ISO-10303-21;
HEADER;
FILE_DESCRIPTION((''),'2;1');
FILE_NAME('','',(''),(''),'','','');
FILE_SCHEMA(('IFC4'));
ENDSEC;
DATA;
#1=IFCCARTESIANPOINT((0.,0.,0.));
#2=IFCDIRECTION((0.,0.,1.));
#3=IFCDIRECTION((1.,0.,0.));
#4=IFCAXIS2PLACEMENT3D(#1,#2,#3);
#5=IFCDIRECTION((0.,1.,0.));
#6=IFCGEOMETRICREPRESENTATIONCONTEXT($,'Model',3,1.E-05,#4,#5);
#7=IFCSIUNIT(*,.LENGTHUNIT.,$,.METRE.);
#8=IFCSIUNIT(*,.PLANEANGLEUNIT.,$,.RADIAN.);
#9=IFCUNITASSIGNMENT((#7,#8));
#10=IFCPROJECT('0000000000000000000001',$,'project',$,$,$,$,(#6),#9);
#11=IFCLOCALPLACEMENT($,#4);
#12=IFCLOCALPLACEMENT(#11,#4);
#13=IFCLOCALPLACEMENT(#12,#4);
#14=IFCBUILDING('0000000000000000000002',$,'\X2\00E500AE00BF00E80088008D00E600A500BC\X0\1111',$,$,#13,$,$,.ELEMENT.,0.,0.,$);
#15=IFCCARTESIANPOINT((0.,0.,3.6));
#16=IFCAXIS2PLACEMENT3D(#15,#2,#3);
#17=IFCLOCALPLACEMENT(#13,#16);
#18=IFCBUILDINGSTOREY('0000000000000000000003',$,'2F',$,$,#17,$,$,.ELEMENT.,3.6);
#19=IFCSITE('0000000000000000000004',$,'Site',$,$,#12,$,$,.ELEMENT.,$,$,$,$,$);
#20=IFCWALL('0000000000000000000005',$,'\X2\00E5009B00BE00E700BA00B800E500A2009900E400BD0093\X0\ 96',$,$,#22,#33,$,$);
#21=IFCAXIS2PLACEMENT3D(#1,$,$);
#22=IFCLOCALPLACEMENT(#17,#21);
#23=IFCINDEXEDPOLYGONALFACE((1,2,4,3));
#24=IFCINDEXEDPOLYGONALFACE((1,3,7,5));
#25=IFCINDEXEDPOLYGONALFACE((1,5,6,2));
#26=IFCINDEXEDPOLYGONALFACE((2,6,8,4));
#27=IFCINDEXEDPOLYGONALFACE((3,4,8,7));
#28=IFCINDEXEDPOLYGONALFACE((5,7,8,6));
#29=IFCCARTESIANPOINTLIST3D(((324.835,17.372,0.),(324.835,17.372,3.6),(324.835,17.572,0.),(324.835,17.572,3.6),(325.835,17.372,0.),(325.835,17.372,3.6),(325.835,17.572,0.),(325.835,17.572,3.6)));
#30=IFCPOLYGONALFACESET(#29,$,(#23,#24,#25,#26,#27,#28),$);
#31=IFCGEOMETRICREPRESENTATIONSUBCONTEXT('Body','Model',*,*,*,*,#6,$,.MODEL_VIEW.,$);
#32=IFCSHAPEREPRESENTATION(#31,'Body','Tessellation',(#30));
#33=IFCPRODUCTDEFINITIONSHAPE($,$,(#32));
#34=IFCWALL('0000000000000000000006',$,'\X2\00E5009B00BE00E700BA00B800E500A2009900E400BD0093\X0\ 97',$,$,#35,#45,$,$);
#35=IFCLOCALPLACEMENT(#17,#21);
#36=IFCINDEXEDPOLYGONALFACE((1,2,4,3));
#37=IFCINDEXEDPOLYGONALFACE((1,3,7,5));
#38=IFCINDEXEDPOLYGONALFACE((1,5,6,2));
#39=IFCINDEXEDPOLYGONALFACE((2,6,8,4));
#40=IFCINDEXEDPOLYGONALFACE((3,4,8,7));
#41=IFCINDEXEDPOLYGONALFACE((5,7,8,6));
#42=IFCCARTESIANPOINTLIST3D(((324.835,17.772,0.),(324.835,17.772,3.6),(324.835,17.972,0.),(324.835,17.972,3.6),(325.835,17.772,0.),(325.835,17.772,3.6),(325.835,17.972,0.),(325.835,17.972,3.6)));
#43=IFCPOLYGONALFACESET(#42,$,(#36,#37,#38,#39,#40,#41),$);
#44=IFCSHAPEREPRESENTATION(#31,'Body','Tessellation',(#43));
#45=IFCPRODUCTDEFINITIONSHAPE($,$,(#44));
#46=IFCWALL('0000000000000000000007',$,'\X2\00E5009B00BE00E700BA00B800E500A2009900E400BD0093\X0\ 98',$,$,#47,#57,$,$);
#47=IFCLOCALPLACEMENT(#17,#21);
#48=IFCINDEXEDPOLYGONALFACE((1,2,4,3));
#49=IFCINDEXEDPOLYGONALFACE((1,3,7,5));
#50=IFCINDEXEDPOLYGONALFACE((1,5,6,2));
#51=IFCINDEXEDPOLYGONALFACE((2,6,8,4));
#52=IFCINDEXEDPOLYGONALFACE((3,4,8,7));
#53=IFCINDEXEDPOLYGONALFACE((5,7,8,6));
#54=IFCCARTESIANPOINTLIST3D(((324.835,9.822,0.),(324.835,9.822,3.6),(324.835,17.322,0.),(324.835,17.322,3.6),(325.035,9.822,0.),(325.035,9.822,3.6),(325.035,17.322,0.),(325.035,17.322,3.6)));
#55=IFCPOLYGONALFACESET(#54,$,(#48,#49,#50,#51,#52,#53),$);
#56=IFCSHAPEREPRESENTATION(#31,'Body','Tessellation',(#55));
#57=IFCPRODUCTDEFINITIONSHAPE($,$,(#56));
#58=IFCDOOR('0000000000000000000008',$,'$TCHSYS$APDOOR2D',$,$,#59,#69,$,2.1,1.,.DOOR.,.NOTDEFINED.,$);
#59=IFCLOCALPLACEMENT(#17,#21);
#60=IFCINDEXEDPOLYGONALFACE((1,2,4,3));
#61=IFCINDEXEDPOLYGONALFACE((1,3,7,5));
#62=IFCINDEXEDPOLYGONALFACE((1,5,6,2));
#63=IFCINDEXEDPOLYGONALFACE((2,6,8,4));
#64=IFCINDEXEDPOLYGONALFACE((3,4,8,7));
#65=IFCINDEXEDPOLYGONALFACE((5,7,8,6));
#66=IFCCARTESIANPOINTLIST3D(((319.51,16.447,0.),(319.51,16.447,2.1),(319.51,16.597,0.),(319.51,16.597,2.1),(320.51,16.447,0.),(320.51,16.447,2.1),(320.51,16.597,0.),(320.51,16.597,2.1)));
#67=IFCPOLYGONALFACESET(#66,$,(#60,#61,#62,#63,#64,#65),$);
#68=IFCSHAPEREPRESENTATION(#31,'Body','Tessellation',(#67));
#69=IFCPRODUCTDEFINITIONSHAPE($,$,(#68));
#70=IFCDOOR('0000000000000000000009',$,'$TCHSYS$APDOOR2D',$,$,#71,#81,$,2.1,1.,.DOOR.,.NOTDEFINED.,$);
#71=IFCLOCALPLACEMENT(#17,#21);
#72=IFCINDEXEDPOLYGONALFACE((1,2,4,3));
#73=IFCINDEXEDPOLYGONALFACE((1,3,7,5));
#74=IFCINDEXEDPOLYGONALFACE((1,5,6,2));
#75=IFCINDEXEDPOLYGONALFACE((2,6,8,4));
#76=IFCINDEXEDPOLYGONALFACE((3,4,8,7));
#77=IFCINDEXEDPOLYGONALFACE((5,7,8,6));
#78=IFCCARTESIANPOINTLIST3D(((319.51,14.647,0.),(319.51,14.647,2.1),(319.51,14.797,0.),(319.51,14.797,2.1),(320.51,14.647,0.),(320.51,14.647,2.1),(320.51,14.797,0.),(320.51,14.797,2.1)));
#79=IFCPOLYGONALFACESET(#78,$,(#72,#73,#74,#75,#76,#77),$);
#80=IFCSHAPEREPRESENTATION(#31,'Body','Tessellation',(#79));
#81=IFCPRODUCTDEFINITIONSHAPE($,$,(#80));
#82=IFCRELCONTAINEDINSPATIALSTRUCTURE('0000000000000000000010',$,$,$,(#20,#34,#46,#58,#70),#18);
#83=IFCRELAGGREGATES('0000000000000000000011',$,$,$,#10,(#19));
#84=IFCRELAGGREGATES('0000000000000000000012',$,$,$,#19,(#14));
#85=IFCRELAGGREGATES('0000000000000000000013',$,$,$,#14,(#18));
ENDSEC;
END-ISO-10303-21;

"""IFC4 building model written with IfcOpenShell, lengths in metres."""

from ifc_helpers import new_model, si_unit, direction, frame, frame_2d, origin_with_axes, place, context, subcontext, project, spatial, rectangle, extrude, element, save


model = new_model("IFC4")

# Units and contexts
model_context = context("Model", 3, precision=1e-05, world=origin_with_axes(), true_north=direction((0.0, 1.0, 0.0)))
body_context = subcontext(model_context, "Body", "Model", "MODEL_VIEW")
ifc_project = project(units=[si_unit("LENGTHUNIT", "METRE"), si_unit("PLANEANGLEUNIT", "RADIAN")], contexts=[model_context])

# Site, building, storey
placement = place(None, origin_with_axes())
site_placement = place(placement, origin_with_axes())
site = spatial("IfcSite", under=ifc_project, at=site_placement, Name="Site", CompositionType="ELEMENT")
building_placement = place(site_placement, origin_with_axes())
building = spatial("IfcBuilding", under=site, at=building_placement, Name="å®¿è\u0088\u008dæ¥¼1111", CompositionType="ELEMENT", ElevationOfRefHeight=0.0, ElevationOfTerrain=0.0)
storey_placement = place(building_placement, frame((0.0, 0.0, 3.6), z_axis=(0.0, 0.0, 1.0), x_axis=(1.0, 0.0, 0.0)))
storey = spatial("IfcBuildingStorey", under=building, at=storey_placement, Name="2F", CompositionType="ELEMENT", Elevation=3.6)

# Walls
for number, where, z_axis, x_axis, name in (
    (1, (325.335, 17.472, 0.0), (0.0, 0.0, 1.0), (1.0, 0.0, 0.0), "å\u009b¾çº¸å¢\u0099ä½\u0093 96"),
    (2, (325.335, 17.872, 0.0), (0.0, 0.0, 1.0), (1.0, 0.0, 0.0), "å\u009b¾çº¸å¢\u0099ä½\u0093 97"),
):
    element("IfcWall", number, at=place(storey_placement, frame(where, z_axis=z_axis, x_axis=x_axis)), inside=storey, Name=name, context=body_context, shape_type="SweptSolid", body=[
        extrude(rectangle(XDim=1.0, YDim=0.2, at=frame_2d((0.0, 0.0), x_axis=(1.0, 0.0, 0.0))), frame((0.0, 0.0, 0.0), z_axis=(0.0, 0.0, 1.0)), (0.0, 0.0, 1.0), 3.6),
    ])
wall_1_placement = place(storey_placement, frame((324.935, 13.572, 0.0), z_axis=(0.0, 0.0, 1.0), x_axis=(0.0, 1.0, 0.0)))
element("IfcWall", 3, at=wall_1_placement, inside=storey, Name="å\u009b¾çº¸å¢\u0099ä½\u0093 98", context=body_context, shape_type="SweptSolid", body=[
    extrude(rectangle(XDim=7.5, YDim=0.2, at=frame_2d((0.0, 0.0), x_axis=(1.0, 0.0, 0.0))), frame((0.0, 0.0, 0.0), z_axis=(0.0, 0.0, 1.0)), (0.0, 0.0, 1.0), 3.6),
])

# Doors
for number, where, z_axis, x_axis, name in (
    (4, (320.01, 16.522, 0.0), (0.0, 0.0, 1.0), (1.0, 0.0, 0.0), "$TCHSYS$APDOOR2D"),
    (5, (320.01, 14.722, 0.0), (0.0, 0.0, 1.0), (1.0, 0.0, 0.0), "$TCHSYS$APDOOR2D"),
):
    element("IfcDoor", number, at=place(storey_placement, frame(where, z_axis=z_axis, x_axis=x_axis)), inside=storey, Name=name, OperationType="NOTDEFINED", OverallHeight=2.1, OverallWidth=1.0, PredefinedType="DOOR", context=body_context, shape_type="SweptSolid", body=[
        extrude(rectangle(XDim=1.0, YDim=0.15, at=frame_2d((0.0, 0.0), x_axis=(1.0, 0.0, 0.0))), frame((0.0, 0.0, 0.0), z_axis=(0.0, 0.0, 1.0)), (0.0, 0.0, 1.0), 2.1),
    ])

save(model, "model.ifc")
